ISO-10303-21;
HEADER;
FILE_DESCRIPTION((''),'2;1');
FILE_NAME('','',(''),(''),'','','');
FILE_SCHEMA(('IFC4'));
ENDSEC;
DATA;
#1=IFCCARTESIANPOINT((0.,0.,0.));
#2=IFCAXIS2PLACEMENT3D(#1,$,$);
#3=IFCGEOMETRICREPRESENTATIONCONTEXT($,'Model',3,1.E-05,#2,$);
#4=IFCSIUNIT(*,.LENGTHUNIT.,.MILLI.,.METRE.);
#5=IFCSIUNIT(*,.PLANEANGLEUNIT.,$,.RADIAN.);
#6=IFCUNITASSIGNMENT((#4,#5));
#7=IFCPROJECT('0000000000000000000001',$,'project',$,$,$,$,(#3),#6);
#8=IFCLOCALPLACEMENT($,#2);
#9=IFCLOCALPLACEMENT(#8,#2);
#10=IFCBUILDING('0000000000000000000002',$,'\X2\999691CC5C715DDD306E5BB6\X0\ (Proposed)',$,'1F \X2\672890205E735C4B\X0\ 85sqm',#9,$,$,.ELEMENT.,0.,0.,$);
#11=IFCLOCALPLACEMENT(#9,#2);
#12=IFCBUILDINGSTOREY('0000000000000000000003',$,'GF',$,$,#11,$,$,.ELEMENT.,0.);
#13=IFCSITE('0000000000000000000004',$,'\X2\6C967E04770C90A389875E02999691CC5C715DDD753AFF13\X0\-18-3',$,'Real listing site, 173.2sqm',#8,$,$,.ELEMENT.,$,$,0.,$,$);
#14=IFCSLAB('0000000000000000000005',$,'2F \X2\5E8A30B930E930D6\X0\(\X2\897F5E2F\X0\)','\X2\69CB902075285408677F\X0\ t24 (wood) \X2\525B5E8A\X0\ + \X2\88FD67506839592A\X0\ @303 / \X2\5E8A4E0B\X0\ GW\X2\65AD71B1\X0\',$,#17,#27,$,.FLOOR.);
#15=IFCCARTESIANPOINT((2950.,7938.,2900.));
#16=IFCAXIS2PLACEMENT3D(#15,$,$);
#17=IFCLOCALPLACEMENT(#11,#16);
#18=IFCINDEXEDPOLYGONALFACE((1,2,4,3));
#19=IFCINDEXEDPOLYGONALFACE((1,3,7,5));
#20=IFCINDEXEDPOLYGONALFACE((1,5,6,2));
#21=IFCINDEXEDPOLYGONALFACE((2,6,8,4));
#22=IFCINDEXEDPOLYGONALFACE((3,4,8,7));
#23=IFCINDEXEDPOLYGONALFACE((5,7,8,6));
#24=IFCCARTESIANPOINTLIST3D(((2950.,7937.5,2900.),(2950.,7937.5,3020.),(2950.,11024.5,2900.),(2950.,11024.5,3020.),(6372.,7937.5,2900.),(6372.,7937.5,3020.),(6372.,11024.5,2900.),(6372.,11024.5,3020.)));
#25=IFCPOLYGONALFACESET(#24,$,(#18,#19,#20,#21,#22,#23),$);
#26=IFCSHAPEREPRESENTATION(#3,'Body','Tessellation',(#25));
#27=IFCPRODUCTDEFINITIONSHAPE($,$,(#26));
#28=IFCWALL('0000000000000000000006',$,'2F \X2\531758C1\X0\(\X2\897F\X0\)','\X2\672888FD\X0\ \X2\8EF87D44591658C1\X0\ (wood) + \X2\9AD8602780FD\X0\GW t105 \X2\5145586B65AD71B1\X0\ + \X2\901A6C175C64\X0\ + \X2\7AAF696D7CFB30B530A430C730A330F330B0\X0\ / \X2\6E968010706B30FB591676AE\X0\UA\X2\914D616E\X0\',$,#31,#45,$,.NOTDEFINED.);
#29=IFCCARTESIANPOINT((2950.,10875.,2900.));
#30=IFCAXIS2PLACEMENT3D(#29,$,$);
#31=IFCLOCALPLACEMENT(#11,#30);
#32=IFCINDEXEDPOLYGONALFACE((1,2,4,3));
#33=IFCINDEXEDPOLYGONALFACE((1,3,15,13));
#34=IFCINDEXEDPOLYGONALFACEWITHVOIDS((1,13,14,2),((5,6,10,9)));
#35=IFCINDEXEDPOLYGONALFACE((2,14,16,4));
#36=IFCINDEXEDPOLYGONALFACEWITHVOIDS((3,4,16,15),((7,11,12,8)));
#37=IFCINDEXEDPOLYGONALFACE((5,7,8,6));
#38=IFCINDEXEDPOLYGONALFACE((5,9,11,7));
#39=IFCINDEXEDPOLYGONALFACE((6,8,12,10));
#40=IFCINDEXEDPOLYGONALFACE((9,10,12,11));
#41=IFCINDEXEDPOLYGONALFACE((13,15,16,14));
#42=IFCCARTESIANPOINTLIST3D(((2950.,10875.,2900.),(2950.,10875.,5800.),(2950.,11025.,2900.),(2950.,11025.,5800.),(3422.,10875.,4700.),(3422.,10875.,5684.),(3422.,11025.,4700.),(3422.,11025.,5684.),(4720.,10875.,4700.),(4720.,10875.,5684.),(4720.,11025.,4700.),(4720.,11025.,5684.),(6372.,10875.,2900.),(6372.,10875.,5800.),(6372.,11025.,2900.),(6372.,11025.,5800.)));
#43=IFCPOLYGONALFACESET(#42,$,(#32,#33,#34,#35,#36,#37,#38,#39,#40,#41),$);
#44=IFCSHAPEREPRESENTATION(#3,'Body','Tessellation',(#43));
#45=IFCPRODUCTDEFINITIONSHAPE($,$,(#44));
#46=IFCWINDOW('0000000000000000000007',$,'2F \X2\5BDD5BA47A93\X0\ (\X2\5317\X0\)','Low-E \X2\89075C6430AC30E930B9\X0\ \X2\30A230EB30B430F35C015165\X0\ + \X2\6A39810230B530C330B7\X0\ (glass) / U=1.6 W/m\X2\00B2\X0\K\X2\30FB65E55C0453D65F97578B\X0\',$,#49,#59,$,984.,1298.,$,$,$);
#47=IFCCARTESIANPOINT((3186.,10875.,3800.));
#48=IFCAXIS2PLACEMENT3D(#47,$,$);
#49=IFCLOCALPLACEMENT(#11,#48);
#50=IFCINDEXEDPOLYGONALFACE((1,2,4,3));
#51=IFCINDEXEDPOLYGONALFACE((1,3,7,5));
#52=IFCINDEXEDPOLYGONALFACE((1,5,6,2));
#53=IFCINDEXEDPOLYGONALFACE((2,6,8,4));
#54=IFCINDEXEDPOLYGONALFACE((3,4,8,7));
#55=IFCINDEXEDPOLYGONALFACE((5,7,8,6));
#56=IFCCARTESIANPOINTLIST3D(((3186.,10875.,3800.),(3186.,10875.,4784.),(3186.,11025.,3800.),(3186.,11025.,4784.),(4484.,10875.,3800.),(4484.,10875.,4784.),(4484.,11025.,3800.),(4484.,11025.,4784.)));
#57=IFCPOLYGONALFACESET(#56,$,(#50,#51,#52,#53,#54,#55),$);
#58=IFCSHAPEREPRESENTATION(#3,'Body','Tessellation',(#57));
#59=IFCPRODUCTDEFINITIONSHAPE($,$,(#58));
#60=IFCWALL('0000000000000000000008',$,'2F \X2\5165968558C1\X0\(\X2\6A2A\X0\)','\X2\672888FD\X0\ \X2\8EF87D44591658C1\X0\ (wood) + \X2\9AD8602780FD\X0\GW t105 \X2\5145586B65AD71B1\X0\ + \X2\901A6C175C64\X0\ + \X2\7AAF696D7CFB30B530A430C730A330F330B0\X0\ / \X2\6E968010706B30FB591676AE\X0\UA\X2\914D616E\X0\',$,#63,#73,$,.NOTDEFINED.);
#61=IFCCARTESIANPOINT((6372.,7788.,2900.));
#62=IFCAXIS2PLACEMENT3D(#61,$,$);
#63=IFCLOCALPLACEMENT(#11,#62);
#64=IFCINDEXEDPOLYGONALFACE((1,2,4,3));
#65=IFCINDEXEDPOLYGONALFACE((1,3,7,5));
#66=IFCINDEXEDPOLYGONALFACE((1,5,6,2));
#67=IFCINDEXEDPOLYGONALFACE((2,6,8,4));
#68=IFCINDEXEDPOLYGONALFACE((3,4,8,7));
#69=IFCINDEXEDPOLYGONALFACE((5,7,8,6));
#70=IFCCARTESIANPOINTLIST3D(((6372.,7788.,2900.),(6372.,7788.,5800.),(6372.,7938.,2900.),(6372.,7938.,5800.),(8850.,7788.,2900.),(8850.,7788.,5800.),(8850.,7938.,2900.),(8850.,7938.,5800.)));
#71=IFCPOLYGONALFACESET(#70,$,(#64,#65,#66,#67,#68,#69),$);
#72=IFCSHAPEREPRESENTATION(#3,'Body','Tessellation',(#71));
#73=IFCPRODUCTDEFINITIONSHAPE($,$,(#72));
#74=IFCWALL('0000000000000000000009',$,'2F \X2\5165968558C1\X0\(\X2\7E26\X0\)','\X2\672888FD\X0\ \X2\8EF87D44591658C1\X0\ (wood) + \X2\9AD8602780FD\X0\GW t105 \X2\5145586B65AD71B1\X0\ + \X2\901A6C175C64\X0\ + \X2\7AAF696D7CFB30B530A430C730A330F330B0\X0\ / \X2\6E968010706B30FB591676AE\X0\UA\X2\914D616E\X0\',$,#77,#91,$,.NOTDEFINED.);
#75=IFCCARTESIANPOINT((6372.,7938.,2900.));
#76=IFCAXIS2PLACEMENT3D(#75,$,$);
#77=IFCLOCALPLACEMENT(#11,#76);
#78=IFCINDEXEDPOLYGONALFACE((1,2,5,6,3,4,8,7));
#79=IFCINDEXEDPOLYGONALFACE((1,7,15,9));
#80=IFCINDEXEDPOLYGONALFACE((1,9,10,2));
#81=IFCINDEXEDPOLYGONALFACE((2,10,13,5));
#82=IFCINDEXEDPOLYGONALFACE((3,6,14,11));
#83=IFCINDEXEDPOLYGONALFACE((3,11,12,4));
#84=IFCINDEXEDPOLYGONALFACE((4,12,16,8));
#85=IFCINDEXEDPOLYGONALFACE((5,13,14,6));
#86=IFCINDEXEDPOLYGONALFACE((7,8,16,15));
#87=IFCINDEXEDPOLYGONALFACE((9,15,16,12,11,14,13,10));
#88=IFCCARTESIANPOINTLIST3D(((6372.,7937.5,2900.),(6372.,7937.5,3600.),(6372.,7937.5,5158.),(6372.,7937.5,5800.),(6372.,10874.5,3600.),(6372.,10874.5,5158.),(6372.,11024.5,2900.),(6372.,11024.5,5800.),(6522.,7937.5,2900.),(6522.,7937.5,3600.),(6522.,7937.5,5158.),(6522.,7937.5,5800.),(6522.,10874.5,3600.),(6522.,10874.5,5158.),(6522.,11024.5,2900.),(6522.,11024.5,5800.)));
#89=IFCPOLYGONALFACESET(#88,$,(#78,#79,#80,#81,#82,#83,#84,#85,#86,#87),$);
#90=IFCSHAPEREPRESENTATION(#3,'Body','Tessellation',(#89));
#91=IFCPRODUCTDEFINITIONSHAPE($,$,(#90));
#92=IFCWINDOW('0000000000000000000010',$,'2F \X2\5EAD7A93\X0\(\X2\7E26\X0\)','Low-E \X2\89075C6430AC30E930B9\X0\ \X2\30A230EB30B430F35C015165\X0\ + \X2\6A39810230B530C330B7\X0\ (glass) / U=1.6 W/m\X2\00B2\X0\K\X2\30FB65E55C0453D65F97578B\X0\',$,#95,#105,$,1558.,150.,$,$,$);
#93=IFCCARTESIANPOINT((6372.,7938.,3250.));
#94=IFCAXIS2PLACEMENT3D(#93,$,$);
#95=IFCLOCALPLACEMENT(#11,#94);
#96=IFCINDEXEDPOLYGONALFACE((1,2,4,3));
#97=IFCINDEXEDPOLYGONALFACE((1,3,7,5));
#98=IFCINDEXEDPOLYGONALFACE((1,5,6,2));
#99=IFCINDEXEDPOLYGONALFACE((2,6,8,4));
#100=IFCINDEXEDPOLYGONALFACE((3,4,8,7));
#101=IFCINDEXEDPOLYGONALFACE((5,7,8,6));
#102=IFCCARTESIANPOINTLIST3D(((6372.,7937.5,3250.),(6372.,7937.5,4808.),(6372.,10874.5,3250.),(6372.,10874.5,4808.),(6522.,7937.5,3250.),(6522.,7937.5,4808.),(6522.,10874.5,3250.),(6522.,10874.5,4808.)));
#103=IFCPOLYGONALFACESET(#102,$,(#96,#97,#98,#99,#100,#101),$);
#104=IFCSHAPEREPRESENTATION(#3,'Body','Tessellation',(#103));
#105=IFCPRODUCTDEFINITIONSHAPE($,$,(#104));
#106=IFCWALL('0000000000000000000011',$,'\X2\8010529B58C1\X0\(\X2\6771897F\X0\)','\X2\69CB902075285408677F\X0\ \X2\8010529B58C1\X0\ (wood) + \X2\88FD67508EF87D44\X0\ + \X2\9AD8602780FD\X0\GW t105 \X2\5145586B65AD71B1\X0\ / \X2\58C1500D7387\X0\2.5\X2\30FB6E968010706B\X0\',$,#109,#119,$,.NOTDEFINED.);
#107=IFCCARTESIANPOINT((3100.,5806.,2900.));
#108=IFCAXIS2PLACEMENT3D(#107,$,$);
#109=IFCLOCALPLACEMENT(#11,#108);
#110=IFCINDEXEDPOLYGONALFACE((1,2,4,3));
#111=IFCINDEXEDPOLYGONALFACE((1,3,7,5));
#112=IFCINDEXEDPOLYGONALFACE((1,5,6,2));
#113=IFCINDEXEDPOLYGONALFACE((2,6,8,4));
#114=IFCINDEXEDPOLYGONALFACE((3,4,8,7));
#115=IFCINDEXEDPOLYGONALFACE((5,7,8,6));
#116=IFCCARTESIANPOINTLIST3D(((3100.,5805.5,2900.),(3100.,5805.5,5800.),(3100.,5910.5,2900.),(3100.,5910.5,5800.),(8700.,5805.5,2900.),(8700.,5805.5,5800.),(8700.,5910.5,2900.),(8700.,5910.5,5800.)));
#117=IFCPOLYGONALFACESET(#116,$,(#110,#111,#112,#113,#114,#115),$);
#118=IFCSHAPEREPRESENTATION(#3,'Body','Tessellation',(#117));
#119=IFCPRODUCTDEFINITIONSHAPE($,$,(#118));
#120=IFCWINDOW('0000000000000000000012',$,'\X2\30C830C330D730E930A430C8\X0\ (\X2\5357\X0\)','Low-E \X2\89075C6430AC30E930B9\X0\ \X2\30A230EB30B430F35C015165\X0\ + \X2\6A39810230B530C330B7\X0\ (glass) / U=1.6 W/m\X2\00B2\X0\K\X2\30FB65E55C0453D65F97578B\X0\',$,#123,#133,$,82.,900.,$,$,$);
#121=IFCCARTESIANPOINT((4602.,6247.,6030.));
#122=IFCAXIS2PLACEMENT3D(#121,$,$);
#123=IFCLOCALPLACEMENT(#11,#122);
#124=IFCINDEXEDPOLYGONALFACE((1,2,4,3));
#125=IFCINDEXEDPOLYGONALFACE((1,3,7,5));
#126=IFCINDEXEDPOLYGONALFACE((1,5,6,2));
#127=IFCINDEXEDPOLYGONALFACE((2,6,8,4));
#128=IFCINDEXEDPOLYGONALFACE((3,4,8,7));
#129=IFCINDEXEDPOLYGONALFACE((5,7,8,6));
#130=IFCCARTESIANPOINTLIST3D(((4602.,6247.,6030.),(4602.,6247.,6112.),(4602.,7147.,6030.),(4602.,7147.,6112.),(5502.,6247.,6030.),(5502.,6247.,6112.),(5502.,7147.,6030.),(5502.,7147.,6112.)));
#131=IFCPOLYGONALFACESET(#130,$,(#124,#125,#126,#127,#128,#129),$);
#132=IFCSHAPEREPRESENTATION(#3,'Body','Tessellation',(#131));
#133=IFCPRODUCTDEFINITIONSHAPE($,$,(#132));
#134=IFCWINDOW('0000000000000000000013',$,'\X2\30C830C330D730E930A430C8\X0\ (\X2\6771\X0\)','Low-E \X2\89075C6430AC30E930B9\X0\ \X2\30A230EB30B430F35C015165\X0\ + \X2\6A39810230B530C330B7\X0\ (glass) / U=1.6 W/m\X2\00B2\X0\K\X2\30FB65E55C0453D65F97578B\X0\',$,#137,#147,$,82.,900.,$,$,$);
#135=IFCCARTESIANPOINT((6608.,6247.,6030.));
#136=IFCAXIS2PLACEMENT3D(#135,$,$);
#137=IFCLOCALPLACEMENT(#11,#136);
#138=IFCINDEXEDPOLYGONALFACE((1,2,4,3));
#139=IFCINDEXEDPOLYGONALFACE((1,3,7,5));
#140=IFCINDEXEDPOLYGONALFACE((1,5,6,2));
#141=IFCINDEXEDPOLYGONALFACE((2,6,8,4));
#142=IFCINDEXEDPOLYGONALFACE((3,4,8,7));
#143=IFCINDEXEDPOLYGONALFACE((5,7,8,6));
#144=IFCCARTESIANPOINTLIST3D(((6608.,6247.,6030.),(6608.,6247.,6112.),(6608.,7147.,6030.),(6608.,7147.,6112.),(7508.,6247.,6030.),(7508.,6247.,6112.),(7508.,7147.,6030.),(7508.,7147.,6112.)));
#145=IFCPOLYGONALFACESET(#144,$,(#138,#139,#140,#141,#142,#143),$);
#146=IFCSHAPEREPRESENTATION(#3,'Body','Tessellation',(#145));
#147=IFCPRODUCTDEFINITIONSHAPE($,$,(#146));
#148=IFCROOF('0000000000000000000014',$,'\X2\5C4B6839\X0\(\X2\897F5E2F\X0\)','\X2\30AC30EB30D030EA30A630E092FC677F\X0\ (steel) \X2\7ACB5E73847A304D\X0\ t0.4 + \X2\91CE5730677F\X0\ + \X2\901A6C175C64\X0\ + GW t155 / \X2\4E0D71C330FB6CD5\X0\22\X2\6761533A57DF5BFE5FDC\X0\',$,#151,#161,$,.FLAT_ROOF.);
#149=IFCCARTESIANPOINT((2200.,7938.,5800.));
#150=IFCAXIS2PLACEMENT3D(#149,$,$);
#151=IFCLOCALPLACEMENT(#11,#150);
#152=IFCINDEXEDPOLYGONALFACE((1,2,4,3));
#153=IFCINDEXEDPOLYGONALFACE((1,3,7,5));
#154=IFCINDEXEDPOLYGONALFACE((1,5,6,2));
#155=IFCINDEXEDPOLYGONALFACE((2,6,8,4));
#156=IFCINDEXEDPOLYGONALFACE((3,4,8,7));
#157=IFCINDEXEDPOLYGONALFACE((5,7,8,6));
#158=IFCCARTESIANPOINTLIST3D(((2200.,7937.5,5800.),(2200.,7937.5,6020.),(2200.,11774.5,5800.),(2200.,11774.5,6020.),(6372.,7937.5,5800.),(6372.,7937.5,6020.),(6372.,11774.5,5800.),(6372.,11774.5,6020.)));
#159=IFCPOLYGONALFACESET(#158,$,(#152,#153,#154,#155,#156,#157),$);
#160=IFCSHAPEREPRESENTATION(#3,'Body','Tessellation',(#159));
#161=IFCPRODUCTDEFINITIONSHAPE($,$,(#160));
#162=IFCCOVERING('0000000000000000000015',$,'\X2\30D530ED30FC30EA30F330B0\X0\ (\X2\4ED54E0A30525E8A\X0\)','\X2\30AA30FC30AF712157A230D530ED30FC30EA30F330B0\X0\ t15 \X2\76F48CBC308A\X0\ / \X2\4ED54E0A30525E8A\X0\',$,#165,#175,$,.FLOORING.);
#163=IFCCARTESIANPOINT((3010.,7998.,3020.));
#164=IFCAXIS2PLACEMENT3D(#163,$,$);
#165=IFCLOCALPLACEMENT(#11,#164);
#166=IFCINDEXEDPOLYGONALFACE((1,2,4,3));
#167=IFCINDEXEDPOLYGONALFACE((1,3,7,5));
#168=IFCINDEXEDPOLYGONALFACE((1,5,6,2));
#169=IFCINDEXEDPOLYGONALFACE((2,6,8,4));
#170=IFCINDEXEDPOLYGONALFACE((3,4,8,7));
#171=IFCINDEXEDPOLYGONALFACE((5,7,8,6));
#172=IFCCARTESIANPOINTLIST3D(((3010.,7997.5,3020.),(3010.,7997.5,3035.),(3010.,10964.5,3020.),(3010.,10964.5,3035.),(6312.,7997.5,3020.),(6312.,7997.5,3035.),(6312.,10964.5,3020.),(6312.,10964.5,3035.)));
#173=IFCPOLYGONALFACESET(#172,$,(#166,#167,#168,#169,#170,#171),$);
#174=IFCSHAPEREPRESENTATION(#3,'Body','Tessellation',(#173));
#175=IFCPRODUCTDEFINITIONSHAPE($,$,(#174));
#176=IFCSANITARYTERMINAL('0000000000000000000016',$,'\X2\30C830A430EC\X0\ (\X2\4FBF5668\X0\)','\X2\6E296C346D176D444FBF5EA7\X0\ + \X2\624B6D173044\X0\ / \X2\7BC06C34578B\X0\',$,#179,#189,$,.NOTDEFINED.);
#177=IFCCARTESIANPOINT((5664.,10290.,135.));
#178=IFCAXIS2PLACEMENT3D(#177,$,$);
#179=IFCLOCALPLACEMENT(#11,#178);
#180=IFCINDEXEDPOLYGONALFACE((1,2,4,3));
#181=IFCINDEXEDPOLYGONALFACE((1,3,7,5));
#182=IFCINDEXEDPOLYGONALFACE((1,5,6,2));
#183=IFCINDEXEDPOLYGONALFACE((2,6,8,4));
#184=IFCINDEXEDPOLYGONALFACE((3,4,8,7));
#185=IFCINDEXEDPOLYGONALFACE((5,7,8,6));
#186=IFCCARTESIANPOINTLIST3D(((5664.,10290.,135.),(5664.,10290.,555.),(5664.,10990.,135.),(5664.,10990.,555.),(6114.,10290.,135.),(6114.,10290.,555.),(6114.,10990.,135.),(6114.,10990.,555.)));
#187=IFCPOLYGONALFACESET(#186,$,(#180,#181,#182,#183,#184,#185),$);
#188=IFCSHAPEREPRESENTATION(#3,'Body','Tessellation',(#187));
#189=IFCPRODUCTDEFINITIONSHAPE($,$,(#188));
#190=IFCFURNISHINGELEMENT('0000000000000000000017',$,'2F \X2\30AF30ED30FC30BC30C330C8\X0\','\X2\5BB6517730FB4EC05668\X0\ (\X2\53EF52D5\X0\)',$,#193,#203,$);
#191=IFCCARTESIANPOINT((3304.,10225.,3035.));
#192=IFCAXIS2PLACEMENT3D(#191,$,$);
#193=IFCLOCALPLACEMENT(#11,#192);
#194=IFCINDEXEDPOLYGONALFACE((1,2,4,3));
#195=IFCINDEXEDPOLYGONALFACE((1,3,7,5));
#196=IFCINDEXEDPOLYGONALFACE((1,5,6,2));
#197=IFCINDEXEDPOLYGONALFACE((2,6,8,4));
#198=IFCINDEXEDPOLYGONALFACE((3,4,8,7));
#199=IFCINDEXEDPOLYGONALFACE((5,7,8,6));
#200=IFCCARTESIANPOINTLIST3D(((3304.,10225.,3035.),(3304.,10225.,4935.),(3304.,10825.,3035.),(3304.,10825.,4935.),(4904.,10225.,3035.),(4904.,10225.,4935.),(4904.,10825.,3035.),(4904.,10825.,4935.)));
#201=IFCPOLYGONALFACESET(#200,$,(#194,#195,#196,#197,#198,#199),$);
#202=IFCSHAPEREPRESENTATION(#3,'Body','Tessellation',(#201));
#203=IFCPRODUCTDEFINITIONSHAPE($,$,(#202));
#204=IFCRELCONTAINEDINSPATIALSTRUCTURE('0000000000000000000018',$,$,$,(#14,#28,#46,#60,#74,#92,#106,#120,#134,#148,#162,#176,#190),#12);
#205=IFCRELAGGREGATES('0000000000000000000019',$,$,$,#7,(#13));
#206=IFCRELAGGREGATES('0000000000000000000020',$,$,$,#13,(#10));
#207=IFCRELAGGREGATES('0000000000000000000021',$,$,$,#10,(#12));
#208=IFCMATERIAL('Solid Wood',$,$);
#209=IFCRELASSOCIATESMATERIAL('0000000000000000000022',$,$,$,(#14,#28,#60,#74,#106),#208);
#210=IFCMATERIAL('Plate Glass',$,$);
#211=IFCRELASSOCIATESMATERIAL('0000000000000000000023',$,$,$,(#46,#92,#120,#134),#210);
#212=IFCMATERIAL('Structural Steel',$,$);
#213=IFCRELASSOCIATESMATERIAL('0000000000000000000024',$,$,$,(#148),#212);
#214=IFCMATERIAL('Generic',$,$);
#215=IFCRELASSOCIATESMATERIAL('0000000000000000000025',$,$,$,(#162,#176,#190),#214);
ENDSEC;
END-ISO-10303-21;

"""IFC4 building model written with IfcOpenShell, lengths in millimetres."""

from ifc_helpers import new_model, si_unit, frame, frame_2d, origin, place, context, project, spatial, rectangle, extrude, material, element, fill, save


model = new_model("IFC4")

# Units and contexts
model_context = context("Model", 3, precision=1e-05, world=origin())
ifc_project = project(units=[si_unit("LENGTHUNIT", "METRE", prefix="MILLI"), si_unit("PLANEANGLEUNIT", "RADIAN")], contexts=[model_context])

# Site, building, storey
site_placement = place(None, origin())
site = spatial("IfcSite", under=ifc_project, at=site_placement, Name="沖縄県那覇市首里山川町３-18-3", ObjectType="Real listing site, 173.2sqm", CompositionType="ELEMENT", RefElevation=0.0)
building_placement = place(site_placement, origin())
building = spatial("IfcBuilding", under=site, at=building_placement, Name="首里山川の家 (Proposed)", ObjectType="1F 木造平屋 85sqm", CompositionType="ELEMENT", ElevationOfRefHeight=0.0, ElevationOfTerrain=0.0)
storey_placement = place(building_placement, origin())
storey = spatial("IfcBuildingStorey", under=building, at=storey_placement, Name="GF", CompositionType="ELEMENT", Elevation=0.0)

# Slab
ifc_material_1 = material(Name="Solid Wood")
slab_placement = place(storey_placement, frame((2950.0, 7938.0, 2900.0)))
element("IfcSlab", 1, at=slab_placement, inside=storey, material=ifc_material_1, Name="2F 床スラブ(西帯)", Description="構造用合板 t24 (wood) 剛床 + 製材根太 @303 / 床下 GW断熱", PredefinedType="FLOOR", context=model_context, shape_type="SweptSolid", body=[
    extrude(rectangle(XDim=3422.0, YDim=3087.0, at=frame_2d((1711.0, 1543.0))), frame((2950.0, 7938.0, 2900.0)), (0.0, 0.0, 1.0), 120.0),
])

# Wall, opening, window
wall_1_placement = place(storey_placement, frame((2950.0, 10875.0, 2900.0)))
wall_1 = element("IfcWall", 2, at=wall_1_placement, inside=storey, material=ifc_material_1, Name="2F 北壁(西)", Description="木製 軸組外壁 (wood) + 高性能GW t105 充填断熱 + 通気層 + 窯業系サイディング / 準耐火・外皮UA配慮", PredefinedType="NOTDEFINED", context=model_context, shape_type="SweptSolid", body=[
    extrude(rectangle(XDim=3422.0, YDim=150.0, at=frame_2d((1711.0, 75.0))), frame((2950.0, 10875.0, 2900.0)), (0.0, 0.0, 1.0), 2900.0),
])
opening_1_placement = place(storey_placement, frame((3186.0, 10875.0, 3800.0)))
opening_1 = element("IfcOpeningElement", 3, at=opening_1_placement, cuts=wall_1, PredefinedType="NOTDEFINED", context=model_context, shape_type="SweptSolid", body=[
    extrude(rectangle(XDim=1298.0, YDim=150.0, at=frame_2d((649.0, 75.0))), frame((3186.0, 10875.0, 3800.0)), (0.0, 0.0, 1.0), 984.0),
])
ifc_material_2 = material(Name="Plate Glass")
window_1_placement = place(storey_placement, frame((3186.0, 10875.0, 3800.0)))
window_1 = element("IfcWindow", 4, at=window_1_placement, inside=storey, material=ifc_material_2, Name="2F 寝室窓 (北)", Description="Low-E 複層ガラス アルゴン封入 + 樹脂サッシ (glass) / U=1.6 W/m²K・日射取得型", OverallHeight=984.0, OverallWidth=1298.0, context=model_context, shape_type="SweptSolid", body=[
    extrude(rectangle(XDim=1298.0, YDim=150.0, at=frame_2d((649.0, 75.0))), frame((3186.0, 10875.0, 3800.0)), (0.0, 0.0, 1.0), 984.0),
])
fill(opening_1, window_1)

# Wall
wall_2_placement = place(storey_placement, frame((6372.0, 7788.0, 2900.0)))
element("IfcWall", 5, at=wall_2_placement, inside=storey, material=ifc_material_1, Name="2F 入隅壁(横)", Description="木製 軸組外壁 (wood) + 高性能GW t105 充填断熱 + 通気層 + 窯業系サイディング / 準耐火・外皮UA配慮", PredefinedType="NOTDEFINED", context=model_context, shape_type="SweptSolid", body=[
    extrude(rectangle(XDim=2478.0, YDim=150.0, at=frame_2d((1239.0, 75.0))), frame((6372.0, 7788.0, 2900.0)), (0.0, 0.0, 1.0), 2900.0),
])

# Wall, opening, window
wall_3_placement = place(storey_placement, frame((6372.0, 7938.0, 2900.0)))
wall_3 = element("IfcWall", 6, at=wall_3_placement, inside=storey, material=ifc_material_1, Name="2F 入隅壁(縦)", Description="木製 軸組外壁 (wood) + 高性能GW t105 充填断熱 + 通気層 + 窯業系サイディング / 準耐火・外皮UA配慮", PredefinedType="NOTDEFINED", context=model_context, shape_type="SweptSolid", body=[
    extrude(rectangle(XDim=150.0, YDim=3087.0, at=frame_2d((75.0, 1543.0))), frame((6372.0, 7938.0, 2900.0)), (0.0, 0.0, 1.0), 2900.0),
])
opening_2_placement = place(storey_placement, frame((6372.0, 7938.0, 3250.0)))
opening_2 = element("IfcOpeningElement", 7, at=opening_2_placement, cuts=wall_3, PredefinedType="NOTDEFINED", context=model_context, shape_type="SweptSolid", body=[
    extrude(rectangle(XDim=150.0, YDim=2937.0, at=frame_2d((75.0, 1468.0))), frame((6372.0, 7938.0, 3250.0)), (0.0, 0.0, 1.0), 1558.0),
])
window_2_placement = place(storey_placement, frame((6372.0, 7938.0, 3250.0)))
window_2 = element("IfcWindow", 8, at=window_2_placement, inside=storey, material=ifc_material_2, Name="2F 庭窓(縦)", Description="Low-E 複層ガラス アルゴン封入 + 樹脂サッシ (glass) / U=1.6 W/m²K・日射取得型", OverallHeight=1558.0, OverallWidth=150.0, context=model_context, shape_type="SweptSolid", body=[
    extrude(rectangle(XDim=150.0, YDim=2937.0, at=frame_2d((75.0, 1468.0))), frame((6372.0, 7938.0, 3250.0)), (0.0, 0.0, 1.0), 1558.0),
])
fill(opening_2, window_2)

# Wall
wall_4_placement = place(storey_placement, frame((3100.0, 5806.0, 2900.0)))
element("IfcWall", 9, at=wall_4_placement, inside=storey, material=ifc_material_1, Name="耐力壁(東西)", Description="構造用合板 耐力壁 (wood) + 製材軸組 + 高性能GW t105 充填断熱 / 壁倍率2.5・準耐火", PredefinedType="NOTDEFINED", context=model_context, shape_type="SweptSolid", body=[
    extrude(rectangle(XDim=5600.0, YDim=105.0, at=frame_2d((2800.0, 52.0))), frame((3100.0, 5806.0, 2900.0)), (0.0, 0.0, 1.0), 2900.0),
])

# Windows
window_3_placement = place(storey_placement, frame((4602.0, 6247.0, 6030.0)))
element("IfcWindow", 10, at=window_3_placement, inside=storey, material=ifc_material_2, Name="トップライト (南)", Description="Low-E 複層ガラス アルゴン封入 + 樹脂サッシ (glass) / U=1.6 W/m²K・日射取得型", OverallHeight=82.0, OverallWidth=900.0, context=model_context, shape_type="SweptSolid", body=[
    extrude(rectangle(XDim=900.0, YDim=900.0, at=frame_2d((450.0, 450.0))), frame((4602.0, 6247.0, 6030.0)), (0.0, 0.0, 1.0), 82.0),
])
window_4_placement = place(storey_placement, frame((6608.0, 6247.0, 6030.0)))
element("IfcWindow", 11, at=window_4_placement, inside=storey, material=ifc_material_2, Name="トップライト (東)", Description="Low-E 複層ガラス アルゴン封入 + 樹脂サッシ (glass) / U=1.6 W/m²K・日射取得型", OverallHeight=82.0, OverallWidth=900.0, context=model_context, shape_type="SweptSolid", body=[
    extrude(rectangle(XDim=900.0, YDim=900.0, at=frame_2d((450.0, 450.0))), frame((6608.0, 6247.0, 6030.0)), (0.0, 0.0, 1.0), 82.0),
])

# Roof
ifc_material_3 = material(Name="Structural Steel")
for number, where, name in (
    (12, (2200.0, 7938.0, 5800.0), "屋根(西帯)"),
):
    element("IfcRoof", number, at=place(storey_placement, frame(where)), inside=storey, material=ifc_material_3, Name=name, Description="ガルバリウム鋼板 (steel) 立平葺き t0.4 + 野地板 + 通気層 + GW t155 / 不燃・法22条区域対応", PredefinedType="FLAT_ROOF", context=model_context, shape_type="SweptSolid", body=[
        extrude(rectangle(XDim=4172.0, YDim=3837.0, at=frame_2d((2086.0, 1918.0))), frame((2200.0, 7938.0, 5800.0)), (0.0, 0.0, 1.0), 220.0),
    ])

# Covering
ifc_material_4 = material(Name="Generic")
covering_placement = place(storey_placement, frame((3010.0, 7998.0, 3020.0)))
element("IfcCovering", 13, at=covering_placement, inside=storey, material=ifc_material_4, Name="フローリング (仕上げ床)", Description="オーク無垢フローリング t15 直貼り / 仕上げ床", PredefinedType="FLOORING", context=model_context, shape_type="SweptSolid", body=[
    extrude(rectangle(XDim=3302.0, YDim=2967.0, at=frame_2d((1651.0, 1483.0))), frame((3010.0, 7998.0, 3020.0)), (0.0, 0.0, 1.0), 15.0),
])

# Sanitary terminal
sanitary_terminal_placement = place(storey_placement, frame((5664.0, 10290.0, 135.0)))
element("IfcSanitaryTerminal", 14, at=sanitary_terminal_placement, inside=storey, material=ifc_material_4, Name="トイレ (便器)", Description="温水洗浄便座 + 手洗い / 節水型", PredefinedType="NOTDEFINED", context=model_context, shape_type="SweptSolid", body=[
    extrude(rectangle(XDim=450.0, YDim=700.0, at=frame_2d((225.0, 350.0))), frame((5664.0, 10290.0, 135.0)), (0.0, 0.0, 1.0), 420.0),
])

# Furnishing element
furnishing_1_placement = place(storey_placement, frame((3304.0, 10225.0, 3035.0)))
element("IfcFurnishingElement", 15, at=furnishing_1_placement, inside=storey, material=ifc_material_4, Name="2F クローゼット", Description="家具・什器 (可動)", context=model_context, shape_type="SweptSolid", body=[
    extrude(rectangle(XDim=1600.0, YDim=600.0, at=frame_2d((800.0, 300.0))), frame((3304.0, 10225.0, 3035.0)), (0.0, 0.0, 1.0), 1900.0),
])

save(model, "model.ifc")
